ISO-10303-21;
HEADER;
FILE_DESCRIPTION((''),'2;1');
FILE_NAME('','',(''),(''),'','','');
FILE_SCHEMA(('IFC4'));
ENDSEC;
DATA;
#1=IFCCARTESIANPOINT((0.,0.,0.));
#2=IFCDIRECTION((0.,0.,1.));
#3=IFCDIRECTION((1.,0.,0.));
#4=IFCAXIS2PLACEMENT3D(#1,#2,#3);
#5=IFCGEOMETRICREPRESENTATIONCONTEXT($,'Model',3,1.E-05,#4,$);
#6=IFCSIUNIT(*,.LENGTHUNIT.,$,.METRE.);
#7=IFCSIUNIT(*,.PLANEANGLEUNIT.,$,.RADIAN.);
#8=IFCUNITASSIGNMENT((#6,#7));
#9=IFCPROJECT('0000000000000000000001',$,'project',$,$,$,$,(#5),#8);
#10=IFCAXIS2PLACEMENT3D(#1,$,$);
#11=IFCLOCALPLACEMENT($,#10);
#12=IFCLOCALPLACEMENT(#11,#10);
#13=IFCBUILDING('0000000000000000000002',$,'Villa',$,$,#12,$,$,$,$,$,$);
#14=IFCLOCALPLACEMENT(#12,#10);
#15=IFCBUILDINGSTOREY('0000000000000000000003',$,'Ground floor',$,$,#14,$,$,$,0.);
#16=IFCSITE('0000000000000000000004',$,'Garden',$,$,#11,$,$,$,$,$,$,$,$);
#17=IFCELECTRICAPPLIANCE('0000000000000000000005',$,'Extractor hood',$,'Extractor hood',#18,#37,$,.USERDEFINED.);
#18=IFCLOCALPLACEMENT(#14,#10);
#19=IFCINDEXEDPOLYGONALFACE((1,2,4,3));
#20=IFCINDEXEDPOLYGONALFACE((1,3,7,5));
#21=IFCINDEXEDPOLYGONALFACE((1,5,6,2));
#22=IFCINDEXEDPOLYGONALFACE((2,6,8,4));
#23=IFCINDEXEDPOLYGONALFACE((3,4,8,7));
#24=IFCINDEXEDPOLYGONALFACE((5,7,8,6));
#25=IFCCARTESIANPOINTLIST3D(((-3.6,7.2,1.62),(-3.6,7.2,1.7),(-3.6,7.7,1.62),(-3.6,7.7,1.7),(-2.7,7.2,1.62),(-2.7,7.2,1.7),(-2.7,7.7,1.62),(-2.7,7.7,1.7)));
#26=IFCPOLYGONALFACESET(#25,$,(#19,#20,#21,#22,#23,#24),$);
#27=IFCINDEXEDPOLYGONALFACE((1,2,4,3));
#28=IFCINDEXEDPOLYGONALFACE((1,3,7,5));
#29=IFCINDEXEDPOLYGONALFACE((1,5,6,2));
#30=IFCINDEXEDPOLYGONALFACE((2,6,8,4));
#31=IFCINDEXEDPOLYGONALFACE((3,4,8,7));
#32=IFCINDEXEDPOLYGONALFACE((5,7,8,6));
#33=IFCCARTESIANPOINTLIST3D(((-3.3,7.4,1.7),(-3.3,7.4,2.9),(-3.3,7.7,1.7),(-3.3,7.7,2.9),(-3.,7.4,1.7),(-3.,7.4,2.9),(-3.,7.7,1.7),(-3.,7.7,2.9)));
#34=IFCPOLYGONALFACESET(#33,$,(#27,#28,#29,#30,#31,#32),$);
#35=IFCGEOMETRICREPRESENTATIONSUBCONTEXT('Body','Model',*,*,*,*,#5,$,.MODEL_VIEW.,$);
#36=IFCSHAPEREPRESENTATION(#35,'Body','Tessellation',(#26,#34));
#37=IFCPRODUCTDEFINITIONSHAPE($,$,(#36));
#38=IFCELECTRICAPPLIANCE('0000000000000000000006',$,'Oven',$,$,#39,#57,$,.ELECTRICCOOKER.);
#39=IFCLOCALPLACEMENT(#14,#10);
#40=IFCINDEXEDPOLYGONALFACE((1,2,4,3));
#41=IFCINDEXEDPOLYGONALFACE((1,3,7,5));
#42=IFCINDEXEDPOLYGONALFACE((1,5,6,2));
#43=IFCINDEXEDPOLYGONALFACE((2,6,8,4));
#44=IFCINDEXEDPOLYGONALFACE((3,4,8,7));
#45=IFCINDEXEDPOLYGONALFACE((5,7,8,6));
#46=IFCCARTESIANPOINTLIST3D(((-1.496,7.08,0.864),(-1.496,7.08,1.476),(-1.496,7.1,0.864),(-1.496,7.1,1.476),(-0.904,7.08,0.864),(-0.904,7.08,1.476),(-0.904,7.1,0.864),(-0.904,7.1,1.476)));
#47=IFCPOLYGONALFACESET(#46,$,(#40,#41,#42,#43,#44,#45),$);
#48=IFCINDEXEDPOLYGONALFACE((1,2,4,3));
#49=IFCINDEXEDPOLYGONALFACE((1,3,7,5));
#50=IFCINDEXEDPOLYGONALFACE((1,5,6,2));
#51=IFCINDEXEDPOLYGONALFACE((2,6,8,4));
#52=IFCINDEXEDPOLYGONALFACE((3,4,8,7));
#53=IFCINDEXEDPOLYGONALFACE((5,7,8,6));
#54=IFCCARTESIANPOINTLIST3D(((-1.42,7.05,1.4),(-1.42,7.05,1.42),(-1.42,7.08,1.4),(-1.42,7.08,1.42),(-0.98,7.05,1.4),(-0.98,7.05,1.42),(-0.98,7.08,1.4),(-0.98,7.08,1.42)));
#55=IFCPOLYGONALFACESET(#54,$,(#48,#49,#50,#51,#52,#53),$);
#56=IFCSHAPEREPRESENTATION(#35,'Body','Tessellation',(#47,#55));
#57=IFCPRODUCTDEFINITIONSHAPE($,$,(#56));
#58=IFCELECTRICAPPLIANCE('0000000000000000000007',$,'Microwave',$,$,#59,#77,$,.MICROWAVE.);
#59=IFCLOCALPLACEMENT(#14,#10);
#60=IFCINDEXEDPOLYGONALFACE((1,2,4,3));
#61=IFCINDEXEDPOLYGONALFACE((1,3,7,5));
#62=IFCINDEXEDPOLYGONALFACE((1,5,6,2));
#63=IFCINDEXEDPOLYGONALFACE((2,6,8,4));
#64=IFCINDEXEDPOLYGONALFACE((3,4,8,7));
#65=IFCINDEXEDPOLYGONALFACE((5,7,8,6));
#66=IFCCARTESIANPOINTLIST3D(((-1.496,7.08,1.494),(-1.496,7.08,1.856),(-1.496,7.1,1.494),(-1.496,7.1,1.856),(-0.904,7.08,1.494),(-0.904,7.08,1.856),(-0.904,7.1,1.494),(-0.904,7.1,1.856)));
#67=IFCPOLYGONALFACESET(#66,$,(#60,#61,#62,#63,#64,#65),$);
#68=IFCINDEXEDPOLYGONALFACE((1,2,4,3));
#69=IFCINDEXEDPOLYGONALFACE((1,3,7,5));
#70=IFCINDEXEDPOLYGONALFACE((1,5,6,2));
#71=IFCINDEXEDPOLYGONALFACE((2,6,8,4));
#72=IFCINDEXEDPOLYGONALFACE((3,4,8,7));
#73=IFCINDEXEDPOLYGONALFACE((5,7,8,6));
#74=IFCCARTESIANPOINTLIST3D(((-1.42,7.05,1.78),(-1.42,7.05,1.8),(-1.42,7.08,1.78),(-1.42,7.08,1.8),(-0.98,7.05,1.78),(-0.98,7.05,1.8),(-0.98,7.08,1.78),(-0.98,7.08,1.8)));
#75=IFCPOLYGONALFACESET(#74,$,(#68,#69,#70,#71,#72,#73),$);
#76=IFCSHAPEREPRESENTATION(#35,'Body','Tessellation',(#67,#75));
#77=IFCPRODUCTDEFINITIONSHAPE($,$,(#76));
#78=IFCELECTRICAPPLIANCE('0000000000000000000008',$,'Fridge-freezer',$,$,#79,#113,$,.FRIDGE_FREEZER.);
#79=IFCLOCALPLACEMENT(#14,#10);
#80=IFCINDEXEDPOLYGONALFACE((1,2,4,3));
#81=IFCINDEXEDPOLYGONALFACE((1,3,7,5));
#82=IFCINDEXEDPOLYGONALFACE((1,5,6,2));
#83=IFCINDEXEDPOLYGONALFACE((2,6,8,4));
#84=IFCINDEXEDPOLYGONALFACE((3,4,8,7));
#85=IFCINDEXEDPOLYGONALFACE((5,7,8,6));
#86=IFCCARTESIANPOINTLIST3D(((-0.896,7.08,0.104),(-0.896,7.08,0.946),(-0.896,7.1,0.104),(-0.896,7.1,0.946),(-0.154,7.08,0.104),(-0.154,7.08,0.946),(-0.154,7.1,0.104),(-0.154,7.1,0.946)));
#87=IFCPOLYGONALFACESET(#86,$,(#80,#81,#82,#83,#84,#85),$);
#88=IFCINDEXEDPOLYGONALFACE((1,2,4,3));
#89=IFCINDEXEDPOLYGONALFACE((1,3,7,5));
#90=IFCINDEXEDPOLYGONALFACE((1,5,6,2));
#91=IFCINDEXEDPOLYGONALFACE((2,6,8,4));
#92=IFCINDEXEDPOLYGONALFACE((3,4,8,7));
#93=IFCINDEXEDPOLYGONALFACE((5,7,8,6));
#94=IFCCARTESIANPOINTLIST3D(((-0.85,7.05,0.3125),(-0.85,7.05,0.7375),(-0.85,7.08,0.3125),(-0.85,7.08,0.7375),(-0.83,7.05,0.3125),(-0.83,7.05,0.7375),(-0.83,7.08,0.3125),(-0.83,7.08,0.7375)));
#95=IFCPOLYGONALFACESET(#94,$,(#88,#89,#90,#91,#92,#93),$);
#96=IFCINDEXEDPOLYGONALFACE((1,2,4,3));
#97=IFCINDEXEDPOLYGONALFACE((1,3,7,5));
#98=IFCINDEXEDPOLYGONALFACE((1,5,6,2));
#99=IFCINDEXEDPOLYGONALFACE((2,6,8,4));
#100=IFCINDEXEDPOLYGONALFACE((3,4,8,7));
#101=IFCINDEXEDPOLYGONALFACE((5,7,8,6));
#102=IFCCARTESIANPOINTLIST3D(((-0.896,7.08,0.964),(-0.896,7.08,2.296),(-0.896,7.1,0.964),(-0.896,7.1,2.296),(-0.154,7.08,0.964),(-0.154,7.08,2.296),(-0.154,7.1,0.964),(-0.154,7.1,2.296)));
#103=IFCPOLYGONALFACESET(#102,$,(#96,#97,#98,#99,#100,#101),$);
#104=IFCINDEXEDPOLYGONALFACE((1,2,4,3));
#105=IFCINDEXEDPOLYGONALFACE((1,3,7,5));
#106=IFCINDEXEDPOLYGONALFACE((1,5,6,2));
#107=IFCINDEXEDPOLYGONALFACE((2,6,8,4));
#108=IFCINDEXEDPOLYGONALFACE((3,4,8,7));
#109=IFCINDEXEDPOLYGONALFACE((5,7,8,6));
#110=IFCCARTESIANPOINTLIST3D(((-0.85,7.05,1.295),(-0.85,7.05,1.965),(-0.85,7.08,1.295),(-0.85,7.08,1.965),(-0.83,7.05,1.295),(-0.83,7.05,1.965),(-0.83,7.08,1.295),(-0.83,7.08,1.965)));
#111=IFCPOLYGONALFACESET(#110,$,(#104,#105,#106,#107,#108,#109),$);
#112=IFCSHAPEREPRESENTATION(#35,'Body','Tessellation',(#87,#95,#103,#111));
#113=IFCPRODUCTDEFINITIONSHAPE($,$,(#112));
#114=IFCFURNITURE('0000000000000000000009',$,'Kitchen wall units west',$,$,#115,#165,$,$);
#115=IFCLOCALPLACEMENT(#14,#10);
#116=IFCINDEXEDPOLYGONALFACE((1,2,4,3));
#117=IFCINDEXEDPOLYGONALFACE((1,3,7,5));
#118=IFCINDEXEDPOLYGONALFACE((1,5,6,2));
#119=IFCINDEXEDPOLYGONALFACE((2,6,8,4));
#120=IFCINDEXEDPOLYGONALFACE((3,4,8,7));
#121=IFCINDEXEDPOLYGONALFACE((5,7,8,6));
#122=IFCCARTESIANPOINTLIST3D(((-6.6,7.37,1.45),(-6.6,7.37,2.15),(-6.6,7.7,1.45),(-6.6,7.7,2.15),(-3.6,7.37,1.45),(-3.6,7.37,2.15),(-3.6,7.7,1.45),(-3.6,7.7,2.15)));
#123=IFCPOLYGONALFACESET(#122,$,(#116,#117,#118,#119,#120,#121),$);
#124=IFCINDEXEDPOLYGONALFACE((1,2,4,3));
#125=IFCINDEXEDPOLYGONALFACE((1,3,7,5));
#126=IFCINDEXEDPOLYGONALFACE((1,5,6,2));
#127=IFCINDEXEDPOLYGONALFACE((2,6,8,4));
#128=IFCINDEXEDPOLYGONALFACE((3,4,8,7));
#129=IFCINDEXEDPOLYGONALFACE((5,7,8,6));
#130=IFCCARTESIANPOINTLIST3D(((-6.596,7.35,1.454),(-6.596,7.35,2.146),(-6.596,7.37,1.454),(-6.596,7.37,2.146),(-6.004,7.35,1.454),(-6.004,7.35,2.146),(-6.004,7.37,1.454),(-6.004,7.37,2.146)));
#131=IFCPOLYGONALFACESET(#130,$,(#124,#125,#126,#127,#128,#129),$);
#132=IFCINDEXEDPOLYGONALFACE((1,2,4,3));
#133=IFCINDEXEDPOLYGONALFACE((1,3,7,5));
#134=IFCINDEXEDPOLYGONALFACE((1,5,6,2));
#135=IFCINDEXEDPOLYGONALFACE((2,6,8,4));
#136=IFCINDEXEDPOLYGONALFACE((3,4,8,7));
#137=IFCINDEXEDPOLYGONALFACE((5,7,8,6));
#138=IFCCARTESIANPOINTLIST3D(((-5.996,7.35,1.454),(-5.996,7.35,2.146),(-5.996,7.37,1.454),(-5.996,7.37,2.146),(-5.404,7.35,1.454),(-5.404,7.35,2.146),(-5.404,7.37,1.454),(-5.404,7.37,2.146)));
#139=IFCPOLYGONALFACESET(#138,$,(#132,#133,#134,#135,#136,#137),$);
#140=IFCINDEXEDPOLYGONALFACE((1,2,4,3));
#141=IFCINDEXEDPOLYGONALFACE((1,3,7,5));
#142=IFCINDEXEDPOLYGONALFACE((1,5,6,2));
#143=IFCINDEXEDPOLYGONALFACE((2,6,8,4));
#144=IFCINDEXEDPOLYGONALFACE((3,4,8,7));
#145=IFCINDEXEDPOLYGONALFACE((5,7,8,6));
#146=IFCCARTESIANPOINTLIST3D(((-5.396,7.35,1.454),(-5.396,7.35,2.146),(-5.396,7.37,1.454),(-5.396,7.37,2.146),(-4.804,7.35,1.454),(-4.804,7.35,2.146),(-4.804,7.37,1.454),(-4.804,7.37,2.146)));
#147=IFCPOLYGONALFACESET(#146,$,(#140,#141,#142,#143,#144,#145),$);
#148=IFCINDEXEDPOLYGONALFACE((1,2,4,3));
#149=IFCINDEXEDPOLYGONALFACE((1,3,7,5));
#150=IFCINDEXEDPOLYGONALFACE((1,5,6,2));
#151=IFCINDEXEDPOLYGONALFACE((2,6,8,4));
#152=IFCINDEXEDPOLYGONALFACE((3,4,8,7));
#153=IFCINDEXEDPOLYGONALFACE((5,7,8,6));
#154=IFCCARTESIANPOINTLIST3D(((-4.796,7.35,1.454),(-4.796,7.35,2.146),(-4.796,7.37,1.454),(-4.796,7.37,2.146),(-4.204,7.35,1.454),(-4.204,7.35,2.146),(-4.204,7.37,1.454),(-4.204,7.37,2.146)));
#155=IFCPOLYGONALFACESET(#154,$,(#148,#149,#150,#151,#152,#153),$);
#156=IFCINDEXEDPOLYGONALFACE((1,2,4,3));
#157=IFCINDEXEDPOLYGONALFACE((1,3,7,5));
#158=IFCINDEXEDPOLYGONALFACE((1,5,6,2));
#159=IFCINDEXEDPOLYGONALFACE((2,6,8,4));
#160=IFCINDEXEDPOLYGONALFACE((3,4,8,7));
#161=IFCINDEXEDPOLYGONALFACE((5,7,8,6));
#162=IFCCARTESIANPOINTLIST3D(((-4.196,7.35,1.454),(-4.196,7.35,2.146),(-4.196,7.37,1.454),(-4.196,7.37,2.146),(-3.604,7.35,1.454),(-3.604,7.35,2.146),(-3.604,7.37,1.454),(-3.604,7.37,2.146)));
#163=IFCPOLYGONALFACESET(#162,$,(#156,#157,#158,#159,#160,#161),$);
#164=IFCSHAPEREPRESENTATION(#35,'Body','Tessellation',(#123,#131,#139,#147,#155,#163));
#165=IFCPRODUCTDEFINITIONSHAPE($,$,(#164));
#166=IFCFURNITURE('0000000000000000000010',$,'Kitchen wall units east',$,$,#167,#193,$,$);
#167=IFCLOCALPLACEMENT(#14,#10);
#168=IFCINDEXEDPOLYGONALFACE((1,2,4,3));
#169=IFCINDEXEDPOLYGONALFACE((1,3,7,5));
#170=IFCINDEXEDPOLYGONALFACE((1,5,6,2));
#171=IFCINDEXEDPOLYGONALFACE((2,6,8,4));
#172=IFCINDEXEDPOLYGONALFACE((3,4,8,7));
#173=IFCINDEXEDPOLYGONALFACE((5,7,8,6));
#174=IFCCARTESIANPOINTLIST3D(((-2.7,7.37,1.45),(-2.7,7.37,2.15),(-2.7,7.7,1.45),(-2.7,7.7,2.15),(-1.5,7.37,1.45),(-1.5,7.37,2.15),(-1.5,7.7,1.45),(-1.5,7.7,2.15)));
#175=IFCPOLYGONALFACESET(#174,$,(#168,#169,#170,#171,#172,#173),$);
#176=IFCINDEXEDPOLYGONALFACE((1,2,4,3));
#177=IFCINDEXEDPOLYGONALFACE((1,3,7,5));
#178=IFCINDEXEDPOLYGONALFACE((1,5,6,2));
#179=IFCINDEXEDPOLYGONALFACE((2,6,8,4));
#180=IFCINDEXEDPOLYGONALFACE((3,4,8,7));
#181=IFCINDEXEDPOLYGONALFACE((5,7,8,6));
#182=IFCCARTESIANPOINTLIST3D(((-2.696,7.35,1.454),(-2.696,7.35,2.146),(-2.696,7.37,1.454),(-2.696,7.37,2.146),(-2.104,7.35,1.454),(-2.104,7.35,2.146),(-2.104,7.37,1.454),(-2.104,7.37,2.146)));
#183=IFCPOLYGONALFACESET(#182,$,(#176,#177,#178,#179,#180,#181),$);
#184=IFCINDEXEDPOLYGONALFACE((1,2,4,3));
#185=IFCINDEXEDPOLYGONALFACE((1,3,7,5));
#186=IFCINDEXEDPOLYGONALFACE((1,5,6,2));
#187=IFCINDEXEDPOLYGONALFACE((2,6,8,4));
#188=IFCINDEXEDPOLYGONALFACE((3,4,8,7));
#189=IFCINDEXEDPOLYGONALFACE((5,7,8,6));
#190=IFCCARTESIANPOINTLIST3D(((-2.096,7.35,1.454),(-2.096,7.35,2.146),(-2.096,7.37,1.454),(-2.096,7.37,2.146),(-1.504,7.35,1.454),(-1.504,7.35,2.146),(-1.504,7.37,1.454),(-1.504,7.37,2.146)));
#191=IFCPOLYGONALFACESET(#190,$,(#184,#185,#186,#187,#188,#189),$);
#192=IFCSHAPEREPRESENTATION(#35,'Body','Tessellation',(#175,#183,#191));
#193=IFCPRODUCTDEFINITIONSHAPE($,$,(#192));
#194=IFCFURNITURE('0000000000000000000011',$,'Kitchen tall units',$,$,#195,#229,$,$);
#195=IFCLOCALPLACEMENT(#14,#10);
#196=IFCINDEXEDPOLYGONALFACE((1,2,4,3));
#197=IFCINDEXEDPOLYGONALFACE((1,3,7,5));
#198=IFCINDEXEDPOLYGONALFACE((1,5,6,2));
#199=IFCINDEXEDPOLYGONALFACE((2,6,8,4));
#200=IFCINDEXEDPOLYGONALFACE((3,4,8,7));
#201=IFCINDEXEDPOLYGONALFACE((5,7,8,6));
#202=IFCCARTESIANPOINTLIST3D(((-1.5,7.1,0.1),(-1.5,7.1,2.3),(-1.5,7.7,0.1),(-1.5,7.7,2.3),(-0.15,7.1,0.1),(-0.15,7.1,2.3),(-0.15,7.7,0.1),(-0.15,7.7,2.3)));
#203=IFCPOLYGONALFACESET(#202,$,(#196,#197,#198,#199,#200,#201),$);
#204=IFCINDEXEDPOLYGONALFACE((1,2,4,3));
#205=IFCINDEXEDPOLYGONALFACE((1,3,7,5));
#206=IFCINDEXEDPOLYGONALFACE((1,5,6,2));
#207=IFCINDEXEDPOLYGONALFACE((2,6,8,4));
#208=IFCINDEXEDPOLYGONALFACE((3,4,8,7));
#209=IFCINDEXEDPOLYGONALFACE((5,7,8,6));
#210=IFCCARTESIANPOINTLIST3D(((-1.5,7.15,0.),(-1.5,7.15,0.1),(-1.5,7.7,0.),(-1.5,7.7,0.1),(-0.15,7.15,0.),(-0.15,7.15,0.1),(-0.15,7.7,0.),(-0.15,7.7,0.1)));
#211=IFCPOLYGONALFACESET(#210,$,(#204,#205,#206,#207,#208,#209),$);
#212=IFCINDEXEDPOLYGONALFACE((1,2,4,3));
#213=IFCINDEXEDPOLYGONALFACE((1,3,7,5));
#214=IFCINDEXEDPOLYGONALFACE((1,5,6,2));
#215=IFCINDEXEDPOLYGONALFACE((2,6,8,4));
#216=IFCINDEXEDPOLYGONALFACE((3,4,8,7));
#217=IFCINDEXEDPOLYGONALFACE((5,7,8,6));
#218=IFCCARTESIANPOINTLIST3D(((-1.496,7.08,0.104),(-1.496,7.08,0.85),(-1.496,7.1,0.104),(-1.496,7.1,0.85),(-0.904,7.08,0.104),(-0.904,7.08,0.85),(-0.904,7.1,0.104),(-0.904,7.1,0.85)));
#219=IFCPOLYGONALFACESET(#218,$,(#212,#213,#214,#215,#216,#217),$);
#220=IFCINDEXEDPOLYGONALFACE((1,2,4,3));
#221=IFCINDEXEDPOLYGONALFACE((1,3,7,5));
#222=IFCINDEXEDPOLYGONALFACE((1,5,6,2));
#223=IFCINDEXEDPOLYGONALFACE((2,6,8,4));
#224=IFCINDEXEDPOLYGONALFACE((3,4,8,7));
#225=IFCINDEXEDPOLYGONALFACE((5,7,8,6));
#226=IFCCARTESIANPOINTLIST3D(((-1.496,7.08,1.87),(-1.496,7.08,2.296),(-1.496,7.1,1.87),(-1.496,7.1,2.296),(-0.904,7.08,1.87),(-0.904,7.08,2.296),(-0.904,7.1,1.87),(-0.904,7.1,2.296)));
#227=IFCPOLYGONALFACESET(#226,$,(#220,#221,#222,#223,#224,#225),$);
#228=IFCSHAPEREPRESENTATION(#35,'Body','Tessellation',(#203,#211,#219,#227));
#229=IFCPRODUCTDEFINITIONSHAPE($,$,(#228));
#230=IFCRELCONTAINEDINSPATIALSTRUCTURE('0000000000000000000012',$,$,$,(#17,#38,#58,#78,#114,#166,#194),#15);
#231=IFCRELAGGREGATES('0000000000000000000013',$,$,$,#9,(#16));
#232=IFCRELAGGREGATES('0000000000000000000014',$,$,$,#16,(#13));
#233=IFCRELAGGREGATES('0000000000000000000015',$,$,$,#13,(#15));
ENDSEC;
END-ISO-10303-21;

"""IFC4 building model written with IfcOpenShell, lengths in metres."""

from ifc_helpers import new_model, si_unit, frame, frame_2d, origin, origin_with_axes, place, context, subcontext, project, spatial, rectangle, extrude, element, save


model = new_model("IFC4")

# Units and contexts
model_context = context("Model", 3, precision=1e-05, world=origin_with_axes())
body_context = subcontext(model_context, "Body", "Model", "MODEL_VIEW")
ifc_project = project(units=[si_unit("LENGTHUNIT", "METRE"), si_unit("PLANEANGLEUNIT", "RADIAN")], contexts=[model_context])

# Site, building, storey
site_placement = place(None, origin())
site = spatial("IfcSite", under=ifc_project, at=site_placement, Name="Garden")
building_placement = place(site_placement, origin())
building = spatial("IfcBuilding", under=site, at=building_placement, Name="Villa")
storey_placement = place(building_placement, origin())
storey = spatial("IfcBuildingStorey", under=building, at=storey_placement, Name="Ground floor", Elevation=0.0)

# Electric appliances
electric_appliance_1_placement = place(storey_placement, frame((-3.6, 7.2, 0.0)))
element("IfcElectricAppliance", 1, at=electric_appliance_1_placement, inside=storey, Name="Extractor hood", ObjectType="Extractor hood", PredefinedType="USERDEFINED", context=body_context, shape_type="SweptSolid", body=[
    extrude(rectangle(XDim=0.9, YDim=0.5, at=frame_2d((0.45, 0.25))), frame((0.0, 0.0, 1.62)), (0.0, 0.0, 1.0), 0.08),
    extrude(rectangle(XDim=0.3, YDim=0.3, at=frame_2d((0.15, 0.15))), frame((0.3, 0.2, 1.7)), (0.0, 0.0, 1.0), 1.2),
])
electric_appliance_2_placement = place(storey_placement, frame((-1.5, 7.08, 0.0)))
element("IfcElectricAppliance", 2, at=electric_appliance_2_placement, inside=storey, Name="Oven", PredefinedType="ELECTRICCOOKER", context=body_context, shape_type="SweptSolid", body=[
    extrude(rectangle(XDim=0.592, YDim=0.02, at=frame_2d((0.296, 0.01))), frame((0.004, 0.0, 0.864)), (0.0, 0.0, 1.0), 0.612),
    extrude(rectangle(XDim=0.44, YDim=0.03, at=frame_2d((0.22, 0.015))), frame((0.08, -0.03, 1.4)), (0.0, 0.0, 1.0), 0.02),
])
electric_appliance_3_placement = place(storey_placement, frame((-1.5, 7.08, 0.0)))
element("IfcElectricAppliance", 3, at=electric_appliance_3_placement, inside=storey, Name="Microwave", PredefinedType="MICROWAVE", context=body_context, shape_type="SweptSolid", body=[
    extrude(rectangle(XDim=0.592, YDim=0.02, at=frame_2d((0.296, 0.01))), frame((0.004, 0.0, 1.494)), (0.0, 0.0, 1.0), 0.362),
    extrude(rectangle(XDim=0.44, YDim=0.03, at=frame_2d((0.22, 0.015))), frame((0.08, -0.03, 1.78)), (0.0, 0.0, 1.0), 0.02),
])
electric_appliance_4_placement = place(storey_placement, frame((-1.5, 7.08, 0.0)))
element("IfcElectricAppliance", 4, at=electric_appliance_4_placement, inside=storey, Name="Fridge-freezer", PredefinedType="FRIDGE_FREEZER", context=body_context, shape_type="SweptSolid", body=[
    extrude(rectangle(XDim=0.742, YDim=0.02, at=frame_2d((0.371, 0.01))), frame((0.604, 0.0, 0.104)), (0.0, 0.0, 1.0), 0.842),
    extrude(rectangle(XDim=0.02, YDim=0.03, at=frame_2d((0.01, 0.015))), frame((0.65, -0.03, 0.3125)), (0.0, 0.0, 1.0), 0.425),
    extrude(rectangle(XDim=0.742, YDim=0.02, at=frame_2d((0.371, 0.01))), frame((0.604, 0.0, 0.964)), (0.0, 0.0, 1.0), 1.332),
    extrude(rectangle(XDim=0.02, YDim=0.03, at=frame_2d((0.01, 0.015))), frame((0.65, -0.03, 1.295)), (0.0, 0.0, 1.0), 0.67),
])

# Furniture
furniture_1_placement = place(storey_placement, frame((-6.6, 7.35, 0.0)))
element("IfcFurniture", 5, at=furniture_1_placement, inside=storey, Name="Kitchen wall units west", context=body_context, shape_type="SweptSolid", body=[
    extrude(rectangle(XDim=3.0, YDim=0.33, at=frame_2d((1.5, 0.165))), frame((0.0, 0.02, 1.45)), (0.0, 0.0, 1.0), 0.7),
    extrude(rectangle(XDim=0.592, YDim=0.02, at=frame_2d((0.296, 0.01))), frame((0.004, 0.0, 1.454)), (0.0, 0.0, 1.0), 0.692),
    extrude(rectangle(XDim=0.592, YDim=0.02, at=frame_2d((0.296, 0.01))), frame((0.604, 0.0, 1.454)), (0.0, 0.0, 1.0), 0.692),
    extrude(rectangle(XDim=0.592, YDim=0.02, at=frame_2d((0.296, 0.01))), frame((1.204, 0.0, 1.454)), (0.0, 0.0, 1.0), 0.692),
    extrude(rectangle(XDim=0.592, YDim=0.02, at=frame_2d((0.296, 0.01))), frame((1.804, 0.0, 1.454)), (0.0, 0.0, 1.0), 0.692),
    extrude(rectangle(XDim=0.592, YDim=0.02, at=frame_2d((0.296, 0.01))), frame((2.404, 0.0, 1.454)), (0.0, 0.0, 1.0), 0.692),
])
furniture_2_placement = place(storey_placement, frame((-2.7, 7.35, 0.0)))
element("IfcFurniture", 6, at=furniture_2_placement, inside=storey, Name="Kitchen wall units east", context=body_context, shape_type="SweptSolid", body=[
    extrude(rectangle(XDim=1.2, YDim=0.33, at=frame_2d((0.6, 0.165))), frame((0.0, 0.02, 1.45)), (0.0, 0.0, 1.0), 0.7),
    extrude(rectangle(XDim=0.592, YDim=0.02, at=frame_2d((0.296, 0.01))), frame((0.004, 0.0, 1.454)), (0.0, 0.0, 1.0), 0.692),
    extrude(rectangle(XDim=0.592, YDim=0.02, at=frame_2d((0.296, 0.01))), frame((0.604, 0.0, 1.454)), (0.0, 0.0, 1.0), 0.692),
])
furniture_3_placement = place(storey_placement, frame((-1.5, 7.08, 0.0)))
element("IfcFurniture", 7, at=furniture_3_placement, inside=storey, Name="Kitchen tall units", context=body_context, shape_type="SweptSolid", body=[
    extrude(rectangle(XDim=1.35, YDim=0.6, at=frame_2d((0.675, 0.3))), frame((0.0, 0.02, 0.1)), (0.0, 0.0, 1.0), 2.2),
    extrude(rectangle(XDim=1.35, YDim=0.55, at=frame_2d((0.675, 0.275))), frame((0.0, 0.07, 0.0)), (0.0, 0.0, 1.0), 0.1),
    extrude(rectangle(XDim=0.592, YDim=0.02, at=frame_2d((0.296, 0.01))), frame((0.004, 0.0, 0.104)), (0.0, 0.0, 1.0), 0.746),
    extrude(rectangle(XDim=0.592, YDim=0.02, at=frame_2d((0.296, 0.01))), frame((0.004, 0.0, 1.87)), (0.0, 0.0, 1.0), 0.426),
])

save(model, "model.ifc")
